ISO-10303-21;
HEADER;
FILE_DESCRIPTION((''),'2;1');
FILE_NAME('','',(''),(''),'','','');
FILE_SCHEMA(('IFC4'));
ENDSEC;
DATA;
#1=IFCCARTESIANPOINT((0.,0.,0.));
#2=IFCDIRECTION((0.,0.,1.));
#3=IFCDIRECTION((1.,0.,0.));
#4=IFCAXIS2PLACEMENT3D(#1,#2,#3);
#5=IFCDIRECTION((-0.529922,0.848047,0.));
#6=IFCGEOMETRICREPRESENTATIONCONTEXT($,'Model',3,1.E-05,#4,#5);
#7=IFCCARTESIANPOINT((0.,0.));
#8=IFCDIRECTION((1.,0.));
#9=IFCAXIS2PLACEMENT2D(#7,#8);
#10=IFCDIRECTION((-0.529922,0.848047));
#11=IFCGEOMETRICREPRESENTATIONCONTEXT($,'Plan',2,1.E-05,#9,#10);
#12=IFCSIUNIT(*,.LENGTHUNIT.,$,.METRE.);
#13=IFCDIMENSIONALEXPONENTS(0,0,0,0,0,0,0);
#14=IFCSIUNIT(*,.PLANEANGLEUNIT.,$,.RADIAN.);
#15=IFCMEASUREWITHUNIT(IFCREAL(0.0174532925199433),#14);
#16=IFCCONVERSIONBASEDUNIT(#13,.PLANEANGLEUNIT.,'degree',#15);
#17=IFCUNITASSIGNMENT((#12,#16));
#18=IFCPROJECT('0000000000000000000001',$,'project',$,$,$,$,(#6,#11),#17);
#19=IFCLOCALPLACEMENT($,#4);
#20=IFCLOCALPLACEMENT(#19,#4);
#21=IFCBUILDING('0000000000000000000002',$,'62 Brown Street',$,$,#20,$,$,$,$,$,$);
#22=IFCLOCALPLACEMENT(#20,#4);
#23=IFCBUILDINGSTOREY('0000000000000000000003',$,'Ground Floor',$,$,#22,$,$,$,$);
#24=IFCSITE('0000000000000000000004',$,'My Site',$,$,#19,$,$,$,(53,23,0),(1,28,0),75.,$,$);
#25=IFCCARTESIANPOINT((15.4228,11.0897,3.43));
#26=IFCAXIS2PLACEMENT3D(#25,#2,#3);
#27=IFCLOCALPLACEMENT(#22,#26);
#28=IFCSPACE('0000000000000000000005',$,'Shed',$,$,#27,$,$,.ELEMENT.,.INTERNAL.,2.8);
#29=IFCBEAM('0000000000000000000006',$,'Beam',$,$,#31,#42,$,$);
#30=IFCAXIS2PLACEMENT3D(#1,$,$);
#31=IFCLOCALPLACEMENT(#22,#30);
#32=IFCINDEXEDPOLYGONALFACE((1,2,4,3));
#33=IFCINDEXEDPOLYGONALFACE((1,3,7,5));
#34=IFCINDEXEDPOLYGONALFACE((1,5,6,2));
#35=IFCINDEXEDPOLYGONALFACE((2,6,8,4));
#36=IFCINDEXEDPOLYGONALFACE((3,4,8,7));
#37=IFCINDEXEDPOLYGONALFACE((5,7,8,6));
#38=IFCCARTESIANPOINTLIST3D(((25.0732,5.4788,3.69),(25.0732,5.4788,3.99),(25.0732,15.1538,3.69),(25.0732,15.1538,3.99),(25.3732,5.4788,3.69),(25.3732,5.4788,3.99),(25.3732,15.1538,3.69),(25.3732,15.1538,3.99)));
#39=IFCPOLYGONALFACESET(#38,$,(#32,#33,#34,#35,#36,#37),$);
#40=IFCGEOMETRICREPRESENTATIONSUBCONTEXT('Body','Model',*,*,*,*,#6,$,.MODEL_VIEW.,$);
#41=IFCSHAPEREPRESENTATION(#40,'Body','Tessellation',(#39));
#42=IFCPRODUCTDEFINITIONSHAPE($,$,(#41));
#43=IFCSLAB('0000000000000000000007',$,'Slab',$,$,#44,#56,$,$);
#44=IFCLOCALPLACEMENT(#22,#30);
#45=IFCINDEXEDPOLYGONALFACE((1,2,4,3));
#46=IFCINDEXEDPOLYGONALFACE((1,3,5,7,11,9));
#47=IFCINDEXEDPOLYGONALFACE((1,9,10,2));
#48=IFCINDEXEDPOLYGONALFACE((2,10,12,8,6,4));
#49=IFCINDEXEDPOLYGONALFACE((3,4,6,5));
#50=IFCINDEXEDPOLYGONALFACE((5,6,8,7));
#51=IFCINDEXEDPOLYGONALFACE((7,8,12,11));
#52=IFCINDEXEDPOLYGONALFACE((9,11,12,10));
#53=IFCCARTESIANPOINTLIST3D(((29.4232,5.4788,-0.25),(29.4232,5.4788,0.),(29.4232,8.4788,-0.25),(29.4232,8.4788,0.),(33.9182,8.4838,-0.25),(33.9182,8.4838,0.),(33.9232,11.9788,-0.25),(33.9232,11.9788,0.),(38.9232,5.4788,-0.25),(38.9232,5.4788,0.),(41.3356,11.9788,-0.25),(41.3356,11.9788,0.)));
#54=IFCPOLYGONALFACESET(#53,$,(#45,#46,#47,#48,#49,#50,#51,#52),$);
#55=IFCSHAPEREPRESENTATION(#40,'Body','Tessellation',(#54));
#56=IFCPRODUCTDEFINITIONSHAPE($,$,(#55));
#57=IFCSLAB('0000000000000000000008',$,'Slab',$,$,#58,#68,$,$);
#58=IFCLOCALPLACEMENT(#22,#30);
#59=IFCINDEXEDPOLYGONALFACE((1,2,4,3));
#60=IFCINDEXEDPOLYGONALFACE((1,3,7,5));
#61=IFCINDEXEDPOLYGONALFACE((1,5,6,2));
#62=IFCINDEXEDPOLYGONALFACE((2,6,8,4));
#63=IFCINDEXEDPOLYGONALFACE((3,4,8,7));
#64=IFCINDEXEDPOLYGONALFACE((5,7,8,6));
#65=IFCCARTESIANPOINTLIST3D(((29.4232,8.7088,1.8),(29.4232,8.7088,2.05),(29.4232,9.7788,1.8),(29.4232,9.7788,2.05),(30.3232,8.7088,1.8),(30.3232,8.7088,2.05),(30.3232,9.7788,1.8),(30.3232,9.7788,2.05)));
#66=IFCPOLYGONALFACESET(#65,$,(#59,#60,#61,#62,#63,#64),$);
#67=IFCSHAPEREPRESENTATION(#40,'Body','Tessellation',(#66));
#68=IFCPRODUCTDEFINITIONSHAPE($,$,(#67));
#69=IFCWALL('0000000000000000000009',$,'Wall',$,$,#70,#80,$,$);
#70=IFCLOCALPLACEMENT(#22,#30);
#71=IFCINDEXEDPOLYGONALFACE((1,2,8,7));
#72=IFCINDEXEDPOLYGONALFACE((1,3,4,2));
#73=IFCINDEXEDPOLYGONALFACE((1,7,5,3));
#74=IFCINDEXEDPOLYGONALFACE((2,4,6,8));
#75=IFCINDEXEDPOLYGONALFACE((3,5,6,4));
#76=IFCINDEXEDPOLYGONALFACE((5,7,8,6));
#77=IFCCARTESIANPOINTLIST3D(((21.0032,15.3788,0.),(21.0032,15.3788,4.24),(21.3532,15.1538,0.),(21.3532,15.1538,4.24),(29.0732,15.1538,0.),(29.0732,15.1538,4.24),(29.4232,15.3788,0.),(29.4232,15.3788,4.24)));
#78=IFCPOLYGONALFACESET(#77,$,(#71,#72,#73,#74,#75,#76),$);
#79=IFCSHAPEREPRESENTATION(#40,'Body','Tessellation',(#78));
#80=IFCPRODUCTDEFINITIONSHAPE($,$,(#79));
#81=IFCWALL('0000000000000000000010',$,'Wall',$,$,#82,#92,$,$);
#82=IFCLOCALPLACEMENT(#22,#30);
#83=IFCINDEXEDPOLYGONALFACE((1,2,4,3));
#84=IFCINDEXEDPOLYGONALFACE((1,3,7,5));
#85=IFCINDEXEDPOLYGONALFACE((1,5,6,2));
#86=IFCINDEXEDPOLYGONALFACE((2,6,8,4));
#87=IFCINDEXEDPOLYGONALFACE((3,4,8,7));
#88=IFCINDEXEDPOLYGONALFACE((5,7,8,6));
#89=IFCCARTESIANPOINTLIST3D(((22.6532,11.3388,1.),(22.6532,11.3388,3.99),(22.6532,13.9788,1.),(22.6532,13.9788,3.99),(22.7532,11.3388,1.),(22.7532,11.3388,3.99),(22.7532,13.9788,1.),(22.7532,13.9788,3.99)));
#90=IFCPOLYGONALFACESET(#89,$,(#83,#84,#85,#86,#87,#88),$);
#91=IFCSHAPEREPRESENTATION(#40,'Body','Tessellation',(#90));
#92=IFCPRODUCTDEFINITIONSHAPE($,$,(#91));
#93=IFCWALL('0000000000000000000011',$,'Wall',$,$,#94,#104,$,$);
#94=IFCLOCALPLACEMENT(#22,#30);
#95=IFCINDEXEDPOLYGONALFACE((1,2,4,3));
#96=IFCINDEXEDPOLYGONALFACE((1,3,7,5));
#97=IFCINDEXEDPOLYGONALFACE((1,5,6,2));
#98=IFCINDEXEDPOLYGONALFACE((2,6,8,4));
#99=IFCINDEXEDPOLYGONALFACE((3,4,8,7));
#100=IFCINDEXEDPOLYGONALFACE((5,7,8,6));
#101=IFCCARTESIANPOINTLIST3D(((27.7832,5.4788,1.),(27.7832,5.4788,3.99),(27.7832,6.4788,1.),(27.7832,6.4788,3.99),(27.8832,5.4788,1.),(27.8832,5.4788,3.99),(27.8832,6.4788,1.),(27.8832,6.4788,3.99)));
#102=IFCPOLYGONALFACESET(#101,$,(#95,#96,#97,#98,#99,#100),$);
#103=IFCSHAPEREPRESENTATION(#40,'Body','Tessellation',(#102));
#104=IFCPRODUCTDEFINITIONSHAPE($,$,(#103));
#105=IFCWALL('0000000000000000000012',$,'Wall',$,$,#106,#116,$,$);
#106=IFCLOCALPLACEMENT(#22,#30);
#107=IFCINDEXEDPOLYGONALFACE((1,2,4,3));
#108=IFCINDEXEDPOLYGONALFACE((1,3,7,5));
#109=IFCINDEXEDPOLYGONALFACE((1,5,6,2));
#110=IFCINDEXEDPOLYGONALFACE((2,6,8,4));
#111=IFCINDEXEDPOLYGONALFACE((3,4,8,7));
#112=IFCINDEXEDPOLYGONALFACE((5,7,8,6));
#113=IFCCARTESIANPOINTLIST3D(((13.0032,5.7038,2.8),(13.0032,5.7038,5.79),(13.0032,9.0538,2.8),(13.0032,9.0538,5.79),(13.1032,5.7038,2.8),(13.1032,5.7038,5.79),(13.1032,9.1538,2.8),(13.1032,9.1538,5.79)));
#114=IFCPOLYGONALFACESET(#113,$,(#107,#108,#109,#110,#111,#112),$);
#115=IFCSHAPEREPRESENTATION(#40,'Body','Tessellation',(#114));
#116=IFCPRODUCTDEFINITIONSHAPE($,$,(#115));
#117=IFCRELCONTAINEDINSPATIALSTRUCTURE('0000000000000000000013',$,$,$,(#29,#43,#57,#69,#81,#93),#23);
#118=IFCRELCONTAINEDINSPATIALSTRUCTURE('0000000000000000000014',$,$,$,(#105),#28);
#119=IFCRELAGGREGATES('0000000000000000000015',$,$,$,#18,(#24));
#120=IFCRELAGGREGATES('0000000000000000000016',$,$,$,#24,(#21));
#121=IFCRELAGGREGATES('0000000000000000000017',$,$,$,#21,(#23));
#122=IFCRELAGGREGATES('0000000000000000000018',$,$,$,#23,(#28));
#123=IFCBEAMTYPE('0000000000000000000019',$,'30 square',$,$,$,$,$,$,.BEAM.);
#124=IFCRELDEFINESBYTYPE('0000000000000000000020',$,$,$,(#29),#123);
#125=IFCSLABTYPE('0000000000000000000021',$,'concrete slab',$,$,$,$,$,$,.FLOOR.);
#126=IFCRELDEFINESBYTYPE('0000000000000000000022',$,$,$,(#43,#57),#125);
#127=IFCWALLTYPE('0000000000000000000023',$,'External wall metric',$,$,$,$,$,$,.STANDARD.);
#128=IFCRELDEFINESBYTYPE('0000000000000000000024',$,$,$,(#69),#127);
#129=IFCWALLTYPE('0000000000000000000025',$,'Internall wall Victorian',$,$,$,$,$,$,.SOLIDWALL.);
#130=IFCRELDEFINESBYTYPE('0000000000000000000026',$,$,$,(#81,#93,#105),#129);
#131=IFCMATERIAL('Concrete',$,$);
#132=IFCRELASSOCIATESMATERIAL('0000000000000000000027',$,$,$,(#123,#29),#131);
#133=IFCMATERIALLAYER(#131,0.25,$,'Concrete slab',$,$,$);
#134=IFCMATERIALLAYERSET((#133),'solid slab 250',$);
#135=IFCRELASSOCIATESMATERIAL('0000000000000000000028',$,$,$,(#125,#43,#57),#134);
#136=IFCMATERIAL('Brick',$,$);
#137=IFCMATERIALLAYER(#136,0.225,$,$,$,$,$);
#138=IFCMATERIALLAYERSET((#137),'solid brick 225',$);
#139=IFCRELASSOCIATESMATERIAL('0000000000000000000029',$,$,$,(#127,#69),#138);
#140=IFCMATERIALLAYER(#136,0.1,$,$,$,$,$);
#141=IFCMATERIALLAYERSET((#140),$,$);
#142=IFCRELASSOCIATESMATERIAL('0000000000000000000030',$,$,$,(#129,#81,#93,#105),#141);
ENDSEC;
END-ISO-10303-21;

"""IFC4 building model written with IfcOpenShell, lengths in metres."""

from ifc_helpers import new_model, entity, si_unit, converted_unit, direction, frame, origin_with_axes, origin_2d_with_axis, place, context, subcontext, project, spatial, line, indexed_curve, rectangle, outline, extrude, clip, halfspace, material, layer, layer_set, layer_usage, material_profile, profile_set, profile_usage, type_object, element, save


model = new_model("IFC4")

# Units and contexts
model_context = context("Model", 3, precision=1e-05, world=origin_with_axes(), true_north=direction((-0.529922, 0.848047, 0.0)))
plan_context = context("Plan", 2, precision=1e-05, world=origin_2d_with_axis(), true_north=direction((-0.529922, 0.848047)))
body_context_1 = subcontext(model_context, "Body", "Model", "MODEL_VIEW")
ifc_project = project(units=[si_unit("LENGTHUNIT", "METRE"), converted_unit("PLANEANGLEUNIT", "degree", entity("IfcReal", 0.0174532925199433), si_unit("PLANEANGLEUNIT", "RADIAN"), dimensions=[0, 0, 0, 0, 0, 0, 0])], contexts=[model_context, plan_context])

# Site, building, storey
site_placement = place(None, origin_with_axes())
site = spatial("IfcSite", under=ifc_project, at=site_placement, Name="My Site", RefLatitude=(53, 23, 0), RefLongitude=(1, 28, 0), RefElevation=75.0)
building_placement = place(site_placement, origin_with_axes())
building = spatial("IfcBuilding", under=site, at=building_placement, Name="62 Brown Street")
storey_placement = place(building_placement, origin_with_axes())
storey = spatial("IfcBuildingStorey", under=building, at=storey_placement, Name="Ground Floor")

# Shared definitions
ifc_material_1 = material(Name="Concrete")

# Beam
ifc_material_profile_1 = material_profile(ifc_material_1, rectangle(XDim=0.3, YDim=0.3))
ifc_profile_set_1 = profile_set([ifc_material_profile_1])
ifc_profile_usage_1 = profile_usage(ifc_profile_set_1, cardinal=5)
beam_type = type_object("IfcBeamType", Name="30 square", PredefinedType="BEAM", material=ifc_profile_set_1)
beam_placement = place(storey_placement, frame((25.2232, 5.4788, 3.84), z_axis=(0.0, 1.0, 0.0), x_axis=(-1.0, 0.0, 0.0)))
element("IfcBeam", 1, at=beam_placement, inside=storey, type_object=beam_type, material=ifc_profile_usage_1, Name="Beam", context=body_context_1, shape_type="SweptSolid", body=[
    extrude(rectangle(XDim=0.3, YDim=0.3), origin_with_axes(), (0.0, 0.0, 1.0), 9.675),
])

# Slabs
ifc_layer_1 = layer(ifc_material_1, 0.25, Name="Concrete slab")
ifc_layer_set_1 = layer_set([ifc_layer_1], Name="solid slab 250")
ifc_layer_usage_1 = layer_usage(ifc_layer_set_1, "AXIS3", "POSITIVE", 0.0)
slab_type_1 = type_object("IfcSlabType", Name="concrete slab", PredefinedType="FLOOR", material=ifc_layer_set_1)
slab_1_placement = place(storey_placement, frame((29.4232, 5.4788, -0.25), z_axis=(0.0, 0.0, 1.0), x_axis=(1.0, 0.0, 0.0)))
element("IfcSlab", 2, at=slab_1_placement, inside=storey, type_object=slab_type_1, material=ifc_layer_usage_1, Name="Slab", context=body_context_1, shape_type="SweptSolid", body=[
    extrude(outline(indexed_curve([(0.0, 0.0), (9.5, 0.0), (11.9124, 6.5), (0.0, 3.0), (4.5, 6.5), (4.495, 3.005)], segments=[line(1, 2), line(2, 3), line(3, 5), line(5, 6), line(6, 4), line(4, 1)], self_intersect=False)), None, (0.0, 0.0, 1.0), 0.25),
])
ifc_layer_usage_2 = layer_usage(ifc_layer_set_1, "AXIS3", "POSITIVE", 0.0)
slab_2_placement = place(storey_placement, frame((29.4232, 8.7088, 1.8), z_axis=(0.0, 0.0, 1.0), x_axis=(1.0, 0.0, 0.0)))
element("IfcSlab", 3, at=slab_2_placement, inside=storey, type_object=slab_type_1, material=ifc_layer_usage_2, Name="Slab", context=body_context_1, shape_type="SweptSolid", body=[
    extrude(outline(indexed_curve([(0.9, 1.07), (0.9, 0.0), (0.0, 0.0), (0.0, 1.07)], segments=[line(3, 2), line(2, 1), line(1, 4), line(4, 3)], self_intersect=False)), None, (0.0, 0.0, 1.0), 0.25),
])

# Walls
ifc_material_2 = material(Name="Brick")
ifc_layer_2 = layer(ifc_material_2, 0.225)
ifc_layer_set_2 = layer_set([ifc_layer_2], Name="solid brick 225")
wall_type_1 = type_object("IfcWallType", Name="External wall metric", PredefinedType="STANDARD", material=ifc_layer_set_2)
ifc_layer_usage_3 = layer_usage(ifc_layer_set_2, "AXIS2", "POSITIVE", 0.0)
wall_1_placement = place(storey_placement, frame((29.4232, 15.3788, 0.0), z_axis=(0.0, 0.0, 1.0), x_axis=(-1.0, 0.0, 0.0)))
element("IfcWall", 4, at=wall_1_placement, inside=storey, type_object=wall_type_1, material=ifc_layer_usage_3, Name="Wall", context=body_context_1, shape_type="Clipping", body=[
    clip(clip(extrude(outline(indexed_curve([(0.0, 0.0), (0.0, 0.225), (8.42, 0.225), (8.42, 0.0), (0.0, 0.0)], self_intersect=False)), origin_with_axes(), (0.0, 0.0, 1.0), 4.24), halfspace(frame((8.42, 0.0, 0.0), z_axis=(0.540756, 0.841179, 0.0), x_axis=(-0.841179, 0.540756, 0.0)), False)), halfspace(frame((0.0, 0.0, 0.0), z_axis=(-0.540758, 0.841178, 0.0), x_axis=(0.841178, 0.540758, 0.0)), False)),
])
ifc_layer_3 = layer(ifc_material_2, 0.1)
ifc_layer_set_3 = layer_set([ifc_layer_3])
ifc_layer_usage_4 = layer_usage(ifc_layer_set_3, "AXIS2", "POSITIVE", 0.0)
wall_type_2 = type_object("IfcWallType", Name="Internall wall Victorian", PredefinedType="SOLIDWALL", material=ifc_layer_set_3)
wall_2_placement = place(storey_placement, frame((22.7532, 11.3388, 1.0), z_axis=(0.0, 0.0, 1.0), x_axis=(0.0, 1.0, 0.0)))
element("IfcWall", 5, at=wall_2_placement, inside=storey, type_object=wall_type_2, material=ifc_layer_usage_4, Name="Wall", context=body_context_1, shape_type="SweptSolid", body=[
    extrude(outline(indexed_curve([(0.0, 0.0), (0.0, 0.1), (2.64, 0.1), (2.64, 0.0), (0.0, 0.0)], self_intersect=False)), origin_with_axes(), (0.0, 0.0, 1.0), 2.99),
])
ifc_layer_usage_5 = layer_usage(ifc_layer_set_3, "AXIS2", "POSITIVE", 0.0)
wall_3_placement = place(storey_placement, frame((27.8832, 5.4788, 1.0), z_axis=(0.0, 0.0, 1.0), x_axis=(0.0, 1.0, 0.0)))
element("IfcWall", 6, at=wall_3_placement, inside=storey, type_object=wall_type_2, material=ifc_layer_usage_5, Name="Wall", context=body_context_1, shape_type="SweptSolid", body=[
    extrude(outline(indexed_curve([(0.0, 0.0), (0.0, 0.1), (1.0, 0.1), (1.0, 0.0), (0.0, 0.0)], self_intersect=False)), origin_with_axes(), (0.0, 0.0, 1.0), 2.99),
])

# Shared definitions
space_1_placement = place(storey_placement, frame((15.4228, 11.0897, 3.43), z_axis=(0.0, 0.0, 1.0), x_axis=(1.0, 0.0, 0.0)))
space_1 = spatial("IfcSpace", under=storey, at=space_1_placement, Name="Shed", CompositionType="ELEMENT", PredefinedType="INTERNAL", ElevationWithFlooring=2.8)

# Wall
ifc_layer_usage_6 = layer_usage(ifc_layer_set_3, "AXIS2", "POSITIVE", 0.0)
wall_4_placement = place(None, frame((13.1032, 5.7038, 2.8), z_axis=(0.0, 0.0, 1.0), x_axis=(0.0, 1.0, 0.0)))
element("IfcWall", 7, at=wall_4_placement, inside=space_1, type_object=wall_type_2, material=ifc_layer_usage_6, Name="Wall", context=body_context_1, shape_type="Clipping", body=[
    clip(extrude(outline(indexed_curve([(0.0, 0.0), (0.0, 0.1), (3.45, 0.1), (3.45, 0.0), (0.0, 0.0)], self_intersect=False)), origin_with_axes(), (0.0, 0.0, 1.0), 2.99), halfspace(frame((3.45, 0.0, -2.8), z_axis=(0.70711, 0.707104, 0.0), x_axis=(0.707104, -0.70711, 0.0)), False)),
])

save(model, "model.ifc")
